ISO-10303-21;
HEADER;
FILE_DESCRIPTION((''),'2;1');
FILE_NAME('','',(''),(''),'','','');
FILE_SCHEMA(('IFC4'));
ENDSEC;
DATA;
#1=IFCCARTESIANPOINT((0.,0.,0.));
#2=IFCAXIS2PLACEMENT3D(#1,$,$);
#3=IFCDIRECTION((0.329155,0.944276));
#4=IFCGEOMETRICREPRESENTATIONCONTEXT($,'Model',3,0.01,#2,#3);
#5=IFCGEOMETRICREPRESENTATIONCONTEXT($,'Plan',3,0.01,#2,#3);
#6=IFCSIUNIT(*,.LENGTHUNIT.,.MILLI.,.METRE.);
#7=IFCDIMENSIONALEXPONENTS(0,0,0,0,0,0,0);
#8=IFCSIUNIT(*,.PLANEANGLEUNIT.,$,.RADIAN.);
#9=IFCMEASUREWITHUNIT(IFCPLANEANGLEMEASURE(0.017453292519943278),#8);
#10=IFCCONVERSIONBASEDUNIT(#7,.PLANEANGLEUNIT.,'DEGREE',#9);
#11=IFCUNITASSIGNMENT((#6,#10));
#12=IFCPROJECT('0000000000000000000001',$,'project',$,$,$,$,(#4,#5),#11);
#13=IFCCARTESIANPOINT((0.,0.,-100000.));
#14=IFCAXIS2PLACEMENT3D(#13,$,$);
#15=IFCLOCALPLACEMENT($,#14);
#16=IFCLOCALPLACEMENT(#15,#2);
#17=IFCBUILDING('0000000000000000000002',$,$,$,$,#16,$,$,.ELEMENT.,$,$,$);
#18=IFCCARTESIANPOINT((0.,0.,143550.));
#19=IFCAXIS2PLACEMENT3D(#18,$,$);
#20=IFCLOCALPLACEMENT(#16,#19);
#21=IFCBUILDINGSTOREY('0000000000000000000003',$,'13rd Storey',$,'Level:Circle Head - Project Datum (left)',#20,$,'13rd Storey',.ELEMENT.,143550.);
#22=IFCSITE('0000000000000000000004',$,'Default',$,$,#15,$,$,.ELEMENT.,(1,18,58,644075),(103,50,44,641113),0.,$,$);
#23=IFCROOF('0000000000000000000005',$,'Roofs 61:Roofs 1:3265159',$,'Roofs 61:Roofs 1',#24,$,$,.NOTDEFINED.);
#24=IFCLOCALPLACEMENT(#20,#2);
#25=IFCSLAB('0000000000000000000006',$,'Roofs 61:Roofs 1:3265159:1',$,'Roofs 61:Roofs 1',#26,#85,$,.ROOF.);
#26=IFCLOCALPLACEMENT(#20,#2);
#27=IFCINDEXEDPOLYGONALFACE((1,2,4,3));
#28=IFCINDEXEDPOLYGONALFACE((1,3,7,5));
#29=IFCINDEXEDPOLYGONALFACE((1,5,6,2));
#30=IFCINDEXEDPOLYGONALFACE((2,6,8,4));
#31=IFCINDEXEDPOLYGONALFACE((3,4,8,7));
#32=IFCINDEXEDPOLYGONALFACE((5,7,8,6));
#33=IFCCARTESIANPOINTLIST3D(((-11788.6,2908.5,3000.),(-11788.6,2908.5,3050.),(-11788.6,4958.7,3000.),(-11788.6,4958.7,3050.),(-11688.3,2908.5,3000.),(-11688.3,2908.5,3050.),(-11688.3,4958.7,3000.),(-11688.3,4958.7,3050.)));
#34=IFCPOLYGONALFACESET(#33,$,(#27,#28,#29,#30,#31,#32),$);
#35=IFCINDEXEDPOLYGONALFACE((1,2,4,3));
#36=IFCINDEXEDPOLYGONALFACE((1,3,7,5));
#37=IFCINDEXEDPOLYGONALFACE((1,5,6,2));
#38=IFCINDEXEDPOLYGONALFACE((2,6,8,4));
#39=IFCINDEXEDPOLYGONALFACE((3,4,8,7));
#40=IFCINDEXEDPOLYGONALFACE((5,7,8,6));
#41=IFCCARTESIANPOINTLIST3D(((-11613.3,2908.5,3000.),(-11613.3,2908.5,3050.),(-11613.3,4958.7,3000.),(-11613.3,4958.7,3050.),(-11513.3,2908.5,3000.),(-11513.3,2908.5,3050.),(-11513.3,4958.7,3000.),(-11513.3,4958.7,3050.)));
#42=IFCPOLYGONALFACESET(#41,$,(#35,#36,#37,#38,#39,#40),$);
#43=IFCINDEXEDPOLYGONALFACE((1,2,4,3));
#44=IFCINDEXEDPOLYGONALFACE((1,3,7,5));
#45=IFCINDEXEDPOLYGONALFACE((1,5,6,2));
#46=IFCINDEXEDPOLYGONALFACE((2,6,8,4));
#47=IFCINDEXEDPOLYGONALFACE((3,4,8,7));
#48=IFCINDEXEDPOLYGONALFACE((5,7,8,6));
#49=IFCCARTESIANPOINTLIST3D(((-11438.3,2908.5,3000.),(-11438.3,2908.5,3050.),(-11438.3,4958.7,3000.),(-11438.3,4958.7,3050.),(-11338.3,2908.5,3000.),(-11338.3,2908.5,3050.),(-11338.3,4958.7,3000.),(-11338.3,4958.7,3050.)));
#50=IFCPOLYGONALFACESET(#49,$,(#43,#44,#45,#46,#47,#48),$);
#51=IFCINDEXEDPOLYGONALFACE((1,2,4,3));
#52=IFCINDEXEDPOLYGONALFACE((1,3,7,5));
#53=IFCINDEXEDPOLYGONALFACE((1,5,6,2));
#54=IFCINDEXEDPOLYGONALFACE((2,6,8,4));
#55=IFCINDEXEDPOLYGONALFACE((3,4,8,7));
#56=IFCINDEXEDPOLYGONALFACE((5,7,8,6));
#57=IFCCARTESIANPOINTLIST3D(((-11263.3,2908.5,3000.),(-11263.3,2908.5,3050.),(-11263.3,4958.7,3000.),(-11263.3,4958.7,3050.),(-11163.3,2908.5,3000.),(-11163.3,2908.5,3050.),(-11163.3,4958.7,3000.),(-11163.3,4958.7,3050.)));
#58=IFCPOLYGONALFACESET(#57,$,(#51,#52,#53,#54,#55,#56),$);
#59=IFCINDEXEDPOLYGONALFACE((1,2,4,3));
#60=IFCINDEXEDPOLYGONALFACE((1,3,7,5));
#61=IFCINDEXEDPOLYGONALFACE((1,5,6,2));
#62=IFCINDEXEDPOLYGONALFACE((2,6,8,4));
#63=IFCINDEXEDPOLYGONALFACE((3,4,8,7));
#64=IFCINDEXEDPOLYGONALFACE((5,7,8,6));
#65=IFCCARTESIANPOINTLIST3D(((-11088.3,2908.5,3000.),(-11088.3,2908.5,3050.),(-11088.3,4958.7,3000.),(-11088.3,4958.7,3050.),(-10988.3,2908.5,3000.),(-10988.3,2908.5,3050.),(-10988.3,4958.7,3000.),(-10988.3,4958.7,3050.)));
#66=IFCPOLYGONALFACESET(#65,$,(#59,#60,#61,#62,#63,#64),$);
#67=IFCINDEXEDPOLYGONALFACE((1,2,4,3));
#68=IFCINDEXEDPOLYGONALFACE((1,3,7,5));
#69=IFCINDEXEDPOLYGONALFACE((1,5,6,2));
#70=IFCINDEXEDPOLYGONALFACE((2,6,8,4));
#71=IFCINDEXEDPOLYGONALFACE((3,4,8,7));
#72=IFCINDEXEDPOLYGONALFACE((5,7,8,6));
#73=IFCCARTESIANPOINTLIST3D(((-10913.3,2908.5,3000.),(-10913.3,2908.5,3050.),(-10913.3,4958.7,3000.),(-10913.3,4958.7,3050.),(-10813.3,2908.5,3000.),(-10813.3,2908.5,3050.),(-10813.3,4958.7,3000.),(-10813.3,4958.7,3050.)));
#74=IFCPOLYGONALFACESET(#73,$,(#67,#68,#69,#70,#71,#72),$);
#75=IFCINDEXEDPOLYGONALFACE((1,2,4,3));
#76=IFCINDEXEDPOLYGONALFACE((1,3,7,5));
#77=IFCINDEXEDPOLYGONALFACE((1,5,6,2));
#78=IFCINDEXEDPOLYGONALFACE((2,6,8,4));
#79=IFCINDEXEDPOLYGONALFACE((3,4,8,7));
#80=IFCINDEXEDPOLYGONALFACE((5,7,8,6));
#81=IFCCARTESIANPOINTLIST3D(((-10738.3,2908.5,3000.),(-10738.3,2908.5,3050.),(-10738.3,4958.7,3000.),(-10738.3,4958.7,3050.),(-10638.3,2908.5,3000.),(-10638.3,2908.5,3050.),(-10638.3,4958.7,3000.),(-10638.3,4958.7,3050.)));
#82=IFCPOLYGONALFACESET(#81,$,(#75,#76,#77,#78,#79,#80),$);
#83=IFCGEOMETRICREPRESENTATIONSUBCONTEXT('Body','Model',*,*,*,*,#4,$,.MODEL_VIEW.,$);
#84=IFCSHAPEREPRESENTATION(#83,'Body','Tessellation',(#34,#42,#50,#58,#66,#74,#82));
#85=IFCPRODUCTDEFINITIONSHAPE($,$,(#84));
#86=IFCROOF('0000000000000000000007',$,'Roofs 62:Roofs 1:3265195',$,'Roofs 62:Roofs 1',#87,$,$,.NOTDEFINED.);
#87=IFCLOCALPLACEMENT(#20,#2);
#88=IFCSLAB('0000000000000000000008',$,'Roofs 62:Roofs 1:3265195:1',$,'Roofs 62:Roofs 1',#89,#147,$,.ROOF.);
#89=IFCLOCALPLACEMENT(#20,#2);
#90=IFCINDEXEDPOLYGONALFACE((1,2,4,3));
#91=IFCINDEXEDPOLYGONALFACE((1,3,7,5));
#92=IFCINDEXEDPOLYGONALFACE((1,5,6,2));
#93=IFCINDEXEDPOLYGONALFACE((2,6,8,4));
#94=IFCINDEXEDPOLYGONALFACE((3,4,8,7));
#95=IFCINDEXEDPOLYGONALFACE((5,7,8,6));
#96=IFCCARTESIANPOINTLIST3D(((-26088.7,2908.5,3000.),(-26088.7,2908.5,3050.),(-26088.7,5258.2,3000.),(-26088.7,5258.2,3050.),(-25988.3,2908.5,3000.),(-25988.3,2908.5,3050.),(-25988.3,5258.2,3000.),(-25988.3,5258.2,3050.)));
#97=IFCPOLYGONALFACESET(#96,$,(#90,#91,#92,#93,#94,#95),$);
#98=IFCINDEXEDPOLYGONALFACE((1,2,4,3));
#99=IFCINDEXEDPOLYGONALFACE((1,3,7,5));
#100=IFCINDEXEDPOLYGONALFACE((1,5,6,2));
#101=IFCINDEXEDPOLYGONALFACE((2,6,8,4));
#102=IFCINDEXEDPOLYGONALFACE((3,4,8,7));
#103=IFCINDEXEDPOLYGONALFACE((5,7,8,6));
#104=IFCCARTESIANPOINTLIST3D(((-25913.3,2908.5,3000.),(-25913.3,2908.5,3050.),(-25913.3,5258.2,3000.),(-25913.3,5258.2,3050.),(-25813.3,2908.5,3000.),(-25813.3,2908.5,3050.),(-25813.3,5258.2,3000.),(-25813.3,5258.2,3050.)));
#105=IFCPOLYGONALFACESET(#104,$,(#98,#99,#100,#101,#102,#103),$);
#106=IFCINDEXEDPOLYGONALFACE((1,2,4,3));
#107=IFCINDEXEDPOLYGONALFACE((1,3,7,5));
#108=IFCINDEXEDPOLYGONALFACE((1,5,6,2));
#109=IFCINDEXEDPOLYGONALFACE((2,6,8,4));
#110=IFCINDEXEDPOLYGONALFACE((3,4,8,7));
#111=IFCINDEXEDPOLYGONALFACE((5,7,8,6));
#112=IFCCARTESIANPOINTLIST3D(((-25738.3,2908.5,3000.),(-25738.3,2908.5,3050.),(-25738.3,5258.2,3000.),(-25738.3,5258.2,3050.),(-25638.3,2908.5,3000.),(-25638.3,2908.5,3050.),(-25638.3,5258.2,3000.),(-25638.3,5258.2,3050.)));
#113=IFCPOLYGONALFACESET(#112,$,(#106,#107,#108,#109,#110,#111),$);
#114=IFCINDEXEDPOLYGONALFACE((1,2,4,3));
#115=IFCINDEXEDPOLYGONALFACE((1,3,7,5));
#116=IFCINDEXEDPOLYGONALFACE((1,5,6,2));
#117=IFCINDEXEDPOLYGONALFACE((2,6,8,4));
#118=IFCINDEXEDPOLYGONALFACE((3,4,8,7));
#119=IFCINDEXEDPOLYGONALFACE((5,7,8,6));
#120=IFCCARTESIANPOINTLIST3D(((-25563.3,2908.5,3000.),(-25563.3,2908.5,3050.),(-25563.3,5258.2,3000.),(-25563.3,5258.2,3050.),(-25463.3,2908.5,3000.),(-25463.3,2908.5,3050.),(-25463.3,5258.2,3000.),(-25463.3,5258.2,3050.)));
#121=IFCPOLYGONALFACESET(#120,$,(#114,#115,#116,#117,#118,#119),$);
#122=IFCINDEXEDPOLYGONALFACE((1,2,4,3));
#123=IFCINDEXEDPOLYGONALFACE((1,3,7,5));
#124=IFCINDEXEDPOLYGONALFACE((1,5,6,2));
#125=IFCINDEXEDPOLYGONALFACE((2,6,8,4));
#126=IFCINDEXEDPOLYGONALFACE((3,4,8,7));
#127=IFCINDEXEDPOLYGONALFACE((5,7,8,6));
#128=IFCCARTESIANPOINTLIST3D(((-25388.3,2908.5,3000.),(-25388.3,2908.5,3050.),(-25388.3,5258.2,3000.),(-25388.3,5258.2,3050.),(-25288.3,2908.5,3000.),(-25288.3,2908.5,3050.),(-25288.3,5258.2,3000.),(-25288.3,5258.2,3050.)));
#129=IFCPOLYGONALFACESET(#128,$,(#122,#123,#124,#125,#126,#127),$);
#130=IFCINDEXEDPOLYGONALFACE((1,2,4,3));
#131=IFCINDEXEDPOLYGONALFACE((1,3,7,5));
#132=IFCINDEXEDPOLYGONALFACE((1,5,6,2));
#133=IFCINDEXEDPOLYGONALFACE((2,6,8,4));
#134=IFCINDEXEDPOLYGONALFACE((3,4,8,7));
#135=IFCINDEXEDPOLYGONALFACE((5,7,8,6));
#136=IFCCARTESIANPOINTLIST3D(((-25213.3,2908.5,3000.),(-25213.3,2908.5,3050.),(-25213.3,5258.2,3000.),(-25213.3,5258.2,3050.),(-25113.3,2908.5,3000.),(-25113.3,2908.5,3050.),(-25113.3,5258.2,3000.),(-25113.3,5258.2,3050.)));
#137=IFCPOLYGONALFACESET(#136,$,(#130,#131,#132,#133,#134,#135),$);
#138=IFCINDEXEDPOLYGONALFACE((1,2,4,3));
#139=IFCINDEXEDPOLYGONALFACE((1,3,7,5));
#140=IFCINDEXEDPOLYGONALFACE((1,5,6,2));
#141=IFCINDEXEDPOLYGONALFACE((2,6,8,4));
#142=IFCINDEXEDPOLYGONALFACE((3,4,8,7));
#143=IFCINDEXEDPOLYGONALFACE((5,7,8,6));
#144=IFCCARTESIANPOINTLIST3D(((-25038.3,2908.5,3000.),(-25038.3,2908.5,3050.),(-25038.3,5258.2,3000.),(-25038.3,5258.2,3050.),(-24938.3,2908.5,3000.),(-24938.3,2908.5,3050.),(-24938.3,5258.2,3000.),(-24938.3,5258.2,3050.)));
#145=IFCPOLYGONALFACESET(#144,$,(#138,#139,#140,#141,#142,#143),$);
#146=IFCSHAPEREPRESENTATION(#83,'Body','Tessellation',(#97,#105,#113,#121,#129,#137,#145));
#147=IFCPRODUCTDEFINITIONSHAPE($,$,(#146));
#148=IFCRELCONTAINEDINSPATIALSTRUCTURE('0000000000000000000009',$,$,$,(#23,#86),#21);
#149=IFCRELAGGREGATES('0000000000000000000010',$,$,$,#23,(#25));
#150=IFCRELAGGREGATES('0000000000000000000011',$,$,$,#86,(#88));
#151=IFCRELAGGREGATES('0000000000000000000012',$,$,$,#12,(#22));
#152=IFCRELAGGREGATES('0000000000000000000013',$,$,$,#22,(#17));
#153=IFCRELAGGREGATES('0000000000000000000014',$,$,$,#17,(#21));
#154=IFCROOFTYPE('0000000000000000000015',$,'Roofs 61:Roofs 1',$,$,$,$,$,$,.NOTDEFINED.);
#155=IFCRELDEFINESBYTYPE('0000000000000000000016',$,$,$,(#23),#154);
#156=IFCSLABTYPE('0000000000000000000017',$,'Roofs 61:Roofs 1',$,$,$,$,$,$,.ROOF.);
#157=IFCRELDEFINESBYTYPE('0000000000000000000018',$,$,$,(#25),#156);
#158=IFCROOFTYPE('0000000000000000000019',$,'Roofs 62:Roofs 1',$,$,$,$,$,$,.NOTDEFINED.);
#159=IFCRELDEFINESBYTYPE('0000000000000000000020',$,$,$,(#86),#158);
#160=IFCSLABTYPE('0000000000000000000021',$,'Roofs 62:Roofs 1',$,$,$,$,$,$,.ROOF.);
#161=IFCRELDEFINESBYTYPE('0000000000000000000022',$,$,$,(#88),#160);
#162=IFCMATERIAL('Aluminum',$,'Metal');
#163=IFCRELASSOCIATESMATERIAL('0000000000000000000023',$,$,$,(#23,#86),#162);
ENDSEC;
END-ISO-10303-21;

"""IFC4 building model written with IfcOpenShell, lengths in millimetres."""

from ifc_helpers import new_model, entity, si_unit, converted_unit, direction, frame, origin, place, context, subcontext, project, spatial, indexed_curve, outline, extrude, material, type_object, element, aggregate, save


model = new_model("IFC4")

# Units and contexts
model_context = context("Model", 3, precision=0.01, world=origin(), true_north=direction((0.329155, 0.944276)))
plan_context = context("Plan", 3, precision=0.01, world=origin(), true_north=direction((0.329155, 0.944276)))
body_context = subcontext(model_context, "Body", "Model", "MODEL_VIEW")
ifc_project = project(units=[si_unit("LENGTHUNIT", "METRE", prefix="MILLI"), converted_unit("PLANEANGLEUNIT", "DEGREE", entity("IfcPlaneAngleMeasure", 0.017453292519943278), si_unit("PLANEANGLEUNIT", "RADIAN"), dimensions=[0, 0, 0, 0, 0, 0, 0])], contexts=[model_context, plan_context])

# Site, building, storey
site_placement = place(None, frame((0.0, 0.0, -100000.0)))
site = spatial("IfcSite", under=ifc_project, at=site_placement, Name="Default", CompositionType="ELEMENT", RefLatitude=(1, 18, 58, 644075), RefLongitude=(103, 50, 44, 641113), RefElevation=0.0)
building_placement = place(site_placement, origin())
building = spatial("IfcBuilding", under=site, at=building_placement, CompositionType="ELEMENT")
storey_placement = place(building_placement, frame((0.0, 0.0, 143550.0)))
storey = spatial("IfcBuildingStorey", under=building, at=storey_placement, Name="13rd Storey", ObjectType="Level:Circle Head - Project Datum (left)", LongName="13rd Storey", CompositionType="ELEMENT", Elevation=143550.0)

# Roofs, slabs
ifc_material_1 = material(Name="Aluminum", Category="Metal")
roof_type_1 = type_object("IfcRoofType", Name="Roofs 61:Roofs 1", PredefinedType="NOTDEFINED")
roof_1_placement = place(storey_placement, frame((0.0, 0.0, -143550.0)))
roof_1 = element("IfcRoof", 1, at=roof_1_placement, inside=storey, type_object=roof_type_1, material=ifc_material_1, Name="Roofs 61:Roofs 1:3265159", ObjectType="Roofs 61:Roofs 1", PredefinedType="NOTDEFINED")
slab_type_1 = type_object("IfcSlabType", Name="Roofs 61:Roofs 1", PredefinedType="ROOF")
slab_1_placement = place(storey_placement, frame((0.0, 0.0, -143550.0)))
slab_1 = element("IfcSlab", 2, at=slab_1_placement, type_object=slab_type_1, Name="Roofs 61:Roofs 1:3265159:1", ObjectType="Roofs 61:Roofs 1", PredefinedType="ROOF", context=body_context, shape_type="SweptSolid", body=[
    extrude(outline(indexed_curve([(-1025.1, -50.2), (1025.1, -50.2), (1025.1, 50.2), (-1025.1, 50.2), (-1025.1, -50.2)], self_intersect=False)), frame((-11738.4, 3933.6, 146550.0), z_axis=(0.0, 0.0, 1.0), x_axis=(0.0, -1.0, 0.0)), (0.0, 0.0, 1.0), 50.0),
    extrude(outline(indexed_curve([(-1025.1, -50.0), (1025.1, -50.0), (1025.1, 50.0), (-1025.1, 50.0), (-1025.1, -50.0)], self_intersect=False)), frame((-11563.3, 3933.6, 146550.0), z_axis=(0.0, 0.0, 1.0), x_axis=(0.0, -1.0, 0.0)), (0.0, 0.0, 1.0), 50.0),
    extrude(outline(indexed_curve([(-1025.1, -50.0), (1025.1, -50.0), (1025.1, 50.0), (-1025.1, 50.0), (-1025.1, -50.0)], self_intersect=False)), frame((-11388.3, 3933.6, 146550.0), z_axis=(0.0, 0.0, 1.0), x_axis=(0.0, -1.0, 0.0)), (0.0, 0.0, 1.0), 50.0),
    extrude(outline(indexed_curve([(-1025.1, -50.0), (1025.1, -50.0), (1025.1, 50.0), (-1025.1, 50.0), (-1025.1, -50.0)], self_intersect=False)), frame((-11213.3, 3933.6, 146550.0), z_axis=(0.0, 0.0, 1.0), x_axis=(0.0, -1.0, 0.0)), (0.0, 0.0, 1.0), 50.0),
    extrude(outline(indexed_curve([(-1025.1, -50.0), (1025.1, -50.0), (1025.1, 50.0), (-1025.1, 50.0), (-1025.1, -50.0)], self_intersect=False)), frame((-11038.3, 3933.6, 146550.0), z_axis=(0.0, 0.0, 1.0), x_axis=(0.0, -1.0, 0.0)), (0.0, 0.0, 1.0), 50.0),
    extrude(outline(indexed_curve([(-1025.1, -50.0), (1025.1, -50.0), (1025.1, 50.0), (-1025.1, 50.0), (-1025.1, -50.0)], self_intersect=False)), frame((-10863.3, 3933.6, 146550.0), z_axis=(0.0, 0.0, 1.0), x_axis=(0.0, -1.0, 0.0)), (0.0, 0.0, 1.0), 50.0),
    extrude(outline(indexed_curve([(-1025.1, -50.0), (1025.1, -50.0), (1025.1, 50.0), (-1025.1, 50.0), (-1025.1, -50.0)], self_intersect=False)), frame((-10688.3, 3933.6, 146550.0), z_axis=(0.0, 0.0, 1.0), x_axis=(0.0, -1.0, 0.0)), (0.0, 0.0, 1.0), 50.0),
])
aggregate(roof_1, [slab_1])
roof_type_2 = type_object("IfcRoofType", Name="Roofs 62:Roofs 1", PredefinedType="NOTDEFINED")
roof_2_placement = place(storey_placement, frame((0.0, 0.0, -143550.0)))
roof_2 = element("IfcRoof", 3, at=roof_2_placement, inside=storey, type_object=roof_type_2, material=ifc_material_1, Name="Roofs 62:Roofs 1:3265195", ObjectType="Roofs 62:Roofs 1", PredefinedType="NOTDEFINED")
slab_type_2 = type_object("IfcSlabType", Name="Roofs 62:Roofs 1", PredefinedType="ROOF")
slab_2_placement = place(storey_placement, frame((0.0, 0.0, -143550.0)))
slab_2 = element("IfcSlab", 4, at=slab_2_placement, type_object=slab_type_2, Name="Roofs 62:Roofs 1:3265195:1", ObjectType="Roofs 62:Roofs 1", PredefinedType="ROOF", context=body_context, shape_type="SweptSolid", body=[
    extrude(outline(indexed_curve([(-1174.9, -50.2), (1174.9, -50.2), (1174.9, 50.2), (-1174.9, 50.2), (-1174.9, -50.2)], self_intersect=False)), frame((-26038.5, 4083.3, 146550.0), z_axis=(0.0, 0.0, 1.0), x_axis=(0.0, -1.0, 0.0)), (0.0, 0.0, 1.0), 50.0),
    extrude(outline(indexed_curve([(-1174.9, -50.0), (1174.9, -50.0), (1174.9, 50.0), (-1174.9, 50.0), (-1174.9, -50.0)], self_intersect=False)), frame((-25863.3, 4083.3, 146550.0), z_axis=(0.0, 0.0, 1.0), x_axis=(0.0, -1.0, 0.0)), (0.0, 0.0, 1.0), 50.0),
    extrude(outline(indexed_curve([(-1174.9, -50.0), (1174.9, -50.0), (1174.9, 50.0), (-1174.9, 50.0), (-1174.9, -50.0)], self_intersect=False)), frame((-25688.3, 4083.3, 146550.0), z_axis=(0.0, 0.0, 1.0), x_axis=(0.0, -1.0, 0.0)), (0.0, 0.0, 1.0), 50.0),
    extrude(outline(indexed_curve([(-1174.9, -50.0), (1174.9, -50.0), (1174.9, 50.0), (-1174.9, 50.0), (-1174.9, -50.0)], self_intersect=False)), frame((-25513.3, 4083.3, 146550.0), z_axis=(0.0, 0.0, 1.0), x_axis=(0.0, -1.0, 0.0)), (0.0, 0.0, 1.0), 50.0),
    extrude(outline(indexed_curve([(-1174.9, -50.0), (1174.9, -50.0), (1174.9, 50.0), (-1174.9, 50.0), (-1174.9, -50.0)], self_intersect=False)), frame((-25338.3, 4083.3, 146550.0), z_axis=(0.0, 0.0, 1.0), x_axis=(0.0, -1.0, 0.0)), (0.0, 0.0, 1.0), 50.0),
    extrude(outline(indexed_curve([(-1174.9, -50.0), (1174.9, -50.0), (1174.9, 50.0), (-1174.9, 50.0), (-1174.9, -50.0)], self_intersect=False)), frame((-25163.3, 4083.3, 146550.0), z_axis=(0.0, 0.0, 1.0), x_axis=(0.0, -1.0, 0.0)), (0.0, 0.0, 1.0), 50.0),
    extrude(outline(indexed_curve([(-1174.9, -50.0), (1174.9, -50.0), (1174.9, 50.0), (-1174.9, 50.0), (-1174.9, -50.0)], self_intersect=False)), frame((-24988.3, 4083.3, 146550.0), z_axis=(0.0, 0.0, 1.0), x_axis=(0.0, -1.0, 0.0)), (0.0, 0.0, 1.0), 50.0),
])
aggregate(roof_2, [slab_2])

save(model, "model.ifc")
